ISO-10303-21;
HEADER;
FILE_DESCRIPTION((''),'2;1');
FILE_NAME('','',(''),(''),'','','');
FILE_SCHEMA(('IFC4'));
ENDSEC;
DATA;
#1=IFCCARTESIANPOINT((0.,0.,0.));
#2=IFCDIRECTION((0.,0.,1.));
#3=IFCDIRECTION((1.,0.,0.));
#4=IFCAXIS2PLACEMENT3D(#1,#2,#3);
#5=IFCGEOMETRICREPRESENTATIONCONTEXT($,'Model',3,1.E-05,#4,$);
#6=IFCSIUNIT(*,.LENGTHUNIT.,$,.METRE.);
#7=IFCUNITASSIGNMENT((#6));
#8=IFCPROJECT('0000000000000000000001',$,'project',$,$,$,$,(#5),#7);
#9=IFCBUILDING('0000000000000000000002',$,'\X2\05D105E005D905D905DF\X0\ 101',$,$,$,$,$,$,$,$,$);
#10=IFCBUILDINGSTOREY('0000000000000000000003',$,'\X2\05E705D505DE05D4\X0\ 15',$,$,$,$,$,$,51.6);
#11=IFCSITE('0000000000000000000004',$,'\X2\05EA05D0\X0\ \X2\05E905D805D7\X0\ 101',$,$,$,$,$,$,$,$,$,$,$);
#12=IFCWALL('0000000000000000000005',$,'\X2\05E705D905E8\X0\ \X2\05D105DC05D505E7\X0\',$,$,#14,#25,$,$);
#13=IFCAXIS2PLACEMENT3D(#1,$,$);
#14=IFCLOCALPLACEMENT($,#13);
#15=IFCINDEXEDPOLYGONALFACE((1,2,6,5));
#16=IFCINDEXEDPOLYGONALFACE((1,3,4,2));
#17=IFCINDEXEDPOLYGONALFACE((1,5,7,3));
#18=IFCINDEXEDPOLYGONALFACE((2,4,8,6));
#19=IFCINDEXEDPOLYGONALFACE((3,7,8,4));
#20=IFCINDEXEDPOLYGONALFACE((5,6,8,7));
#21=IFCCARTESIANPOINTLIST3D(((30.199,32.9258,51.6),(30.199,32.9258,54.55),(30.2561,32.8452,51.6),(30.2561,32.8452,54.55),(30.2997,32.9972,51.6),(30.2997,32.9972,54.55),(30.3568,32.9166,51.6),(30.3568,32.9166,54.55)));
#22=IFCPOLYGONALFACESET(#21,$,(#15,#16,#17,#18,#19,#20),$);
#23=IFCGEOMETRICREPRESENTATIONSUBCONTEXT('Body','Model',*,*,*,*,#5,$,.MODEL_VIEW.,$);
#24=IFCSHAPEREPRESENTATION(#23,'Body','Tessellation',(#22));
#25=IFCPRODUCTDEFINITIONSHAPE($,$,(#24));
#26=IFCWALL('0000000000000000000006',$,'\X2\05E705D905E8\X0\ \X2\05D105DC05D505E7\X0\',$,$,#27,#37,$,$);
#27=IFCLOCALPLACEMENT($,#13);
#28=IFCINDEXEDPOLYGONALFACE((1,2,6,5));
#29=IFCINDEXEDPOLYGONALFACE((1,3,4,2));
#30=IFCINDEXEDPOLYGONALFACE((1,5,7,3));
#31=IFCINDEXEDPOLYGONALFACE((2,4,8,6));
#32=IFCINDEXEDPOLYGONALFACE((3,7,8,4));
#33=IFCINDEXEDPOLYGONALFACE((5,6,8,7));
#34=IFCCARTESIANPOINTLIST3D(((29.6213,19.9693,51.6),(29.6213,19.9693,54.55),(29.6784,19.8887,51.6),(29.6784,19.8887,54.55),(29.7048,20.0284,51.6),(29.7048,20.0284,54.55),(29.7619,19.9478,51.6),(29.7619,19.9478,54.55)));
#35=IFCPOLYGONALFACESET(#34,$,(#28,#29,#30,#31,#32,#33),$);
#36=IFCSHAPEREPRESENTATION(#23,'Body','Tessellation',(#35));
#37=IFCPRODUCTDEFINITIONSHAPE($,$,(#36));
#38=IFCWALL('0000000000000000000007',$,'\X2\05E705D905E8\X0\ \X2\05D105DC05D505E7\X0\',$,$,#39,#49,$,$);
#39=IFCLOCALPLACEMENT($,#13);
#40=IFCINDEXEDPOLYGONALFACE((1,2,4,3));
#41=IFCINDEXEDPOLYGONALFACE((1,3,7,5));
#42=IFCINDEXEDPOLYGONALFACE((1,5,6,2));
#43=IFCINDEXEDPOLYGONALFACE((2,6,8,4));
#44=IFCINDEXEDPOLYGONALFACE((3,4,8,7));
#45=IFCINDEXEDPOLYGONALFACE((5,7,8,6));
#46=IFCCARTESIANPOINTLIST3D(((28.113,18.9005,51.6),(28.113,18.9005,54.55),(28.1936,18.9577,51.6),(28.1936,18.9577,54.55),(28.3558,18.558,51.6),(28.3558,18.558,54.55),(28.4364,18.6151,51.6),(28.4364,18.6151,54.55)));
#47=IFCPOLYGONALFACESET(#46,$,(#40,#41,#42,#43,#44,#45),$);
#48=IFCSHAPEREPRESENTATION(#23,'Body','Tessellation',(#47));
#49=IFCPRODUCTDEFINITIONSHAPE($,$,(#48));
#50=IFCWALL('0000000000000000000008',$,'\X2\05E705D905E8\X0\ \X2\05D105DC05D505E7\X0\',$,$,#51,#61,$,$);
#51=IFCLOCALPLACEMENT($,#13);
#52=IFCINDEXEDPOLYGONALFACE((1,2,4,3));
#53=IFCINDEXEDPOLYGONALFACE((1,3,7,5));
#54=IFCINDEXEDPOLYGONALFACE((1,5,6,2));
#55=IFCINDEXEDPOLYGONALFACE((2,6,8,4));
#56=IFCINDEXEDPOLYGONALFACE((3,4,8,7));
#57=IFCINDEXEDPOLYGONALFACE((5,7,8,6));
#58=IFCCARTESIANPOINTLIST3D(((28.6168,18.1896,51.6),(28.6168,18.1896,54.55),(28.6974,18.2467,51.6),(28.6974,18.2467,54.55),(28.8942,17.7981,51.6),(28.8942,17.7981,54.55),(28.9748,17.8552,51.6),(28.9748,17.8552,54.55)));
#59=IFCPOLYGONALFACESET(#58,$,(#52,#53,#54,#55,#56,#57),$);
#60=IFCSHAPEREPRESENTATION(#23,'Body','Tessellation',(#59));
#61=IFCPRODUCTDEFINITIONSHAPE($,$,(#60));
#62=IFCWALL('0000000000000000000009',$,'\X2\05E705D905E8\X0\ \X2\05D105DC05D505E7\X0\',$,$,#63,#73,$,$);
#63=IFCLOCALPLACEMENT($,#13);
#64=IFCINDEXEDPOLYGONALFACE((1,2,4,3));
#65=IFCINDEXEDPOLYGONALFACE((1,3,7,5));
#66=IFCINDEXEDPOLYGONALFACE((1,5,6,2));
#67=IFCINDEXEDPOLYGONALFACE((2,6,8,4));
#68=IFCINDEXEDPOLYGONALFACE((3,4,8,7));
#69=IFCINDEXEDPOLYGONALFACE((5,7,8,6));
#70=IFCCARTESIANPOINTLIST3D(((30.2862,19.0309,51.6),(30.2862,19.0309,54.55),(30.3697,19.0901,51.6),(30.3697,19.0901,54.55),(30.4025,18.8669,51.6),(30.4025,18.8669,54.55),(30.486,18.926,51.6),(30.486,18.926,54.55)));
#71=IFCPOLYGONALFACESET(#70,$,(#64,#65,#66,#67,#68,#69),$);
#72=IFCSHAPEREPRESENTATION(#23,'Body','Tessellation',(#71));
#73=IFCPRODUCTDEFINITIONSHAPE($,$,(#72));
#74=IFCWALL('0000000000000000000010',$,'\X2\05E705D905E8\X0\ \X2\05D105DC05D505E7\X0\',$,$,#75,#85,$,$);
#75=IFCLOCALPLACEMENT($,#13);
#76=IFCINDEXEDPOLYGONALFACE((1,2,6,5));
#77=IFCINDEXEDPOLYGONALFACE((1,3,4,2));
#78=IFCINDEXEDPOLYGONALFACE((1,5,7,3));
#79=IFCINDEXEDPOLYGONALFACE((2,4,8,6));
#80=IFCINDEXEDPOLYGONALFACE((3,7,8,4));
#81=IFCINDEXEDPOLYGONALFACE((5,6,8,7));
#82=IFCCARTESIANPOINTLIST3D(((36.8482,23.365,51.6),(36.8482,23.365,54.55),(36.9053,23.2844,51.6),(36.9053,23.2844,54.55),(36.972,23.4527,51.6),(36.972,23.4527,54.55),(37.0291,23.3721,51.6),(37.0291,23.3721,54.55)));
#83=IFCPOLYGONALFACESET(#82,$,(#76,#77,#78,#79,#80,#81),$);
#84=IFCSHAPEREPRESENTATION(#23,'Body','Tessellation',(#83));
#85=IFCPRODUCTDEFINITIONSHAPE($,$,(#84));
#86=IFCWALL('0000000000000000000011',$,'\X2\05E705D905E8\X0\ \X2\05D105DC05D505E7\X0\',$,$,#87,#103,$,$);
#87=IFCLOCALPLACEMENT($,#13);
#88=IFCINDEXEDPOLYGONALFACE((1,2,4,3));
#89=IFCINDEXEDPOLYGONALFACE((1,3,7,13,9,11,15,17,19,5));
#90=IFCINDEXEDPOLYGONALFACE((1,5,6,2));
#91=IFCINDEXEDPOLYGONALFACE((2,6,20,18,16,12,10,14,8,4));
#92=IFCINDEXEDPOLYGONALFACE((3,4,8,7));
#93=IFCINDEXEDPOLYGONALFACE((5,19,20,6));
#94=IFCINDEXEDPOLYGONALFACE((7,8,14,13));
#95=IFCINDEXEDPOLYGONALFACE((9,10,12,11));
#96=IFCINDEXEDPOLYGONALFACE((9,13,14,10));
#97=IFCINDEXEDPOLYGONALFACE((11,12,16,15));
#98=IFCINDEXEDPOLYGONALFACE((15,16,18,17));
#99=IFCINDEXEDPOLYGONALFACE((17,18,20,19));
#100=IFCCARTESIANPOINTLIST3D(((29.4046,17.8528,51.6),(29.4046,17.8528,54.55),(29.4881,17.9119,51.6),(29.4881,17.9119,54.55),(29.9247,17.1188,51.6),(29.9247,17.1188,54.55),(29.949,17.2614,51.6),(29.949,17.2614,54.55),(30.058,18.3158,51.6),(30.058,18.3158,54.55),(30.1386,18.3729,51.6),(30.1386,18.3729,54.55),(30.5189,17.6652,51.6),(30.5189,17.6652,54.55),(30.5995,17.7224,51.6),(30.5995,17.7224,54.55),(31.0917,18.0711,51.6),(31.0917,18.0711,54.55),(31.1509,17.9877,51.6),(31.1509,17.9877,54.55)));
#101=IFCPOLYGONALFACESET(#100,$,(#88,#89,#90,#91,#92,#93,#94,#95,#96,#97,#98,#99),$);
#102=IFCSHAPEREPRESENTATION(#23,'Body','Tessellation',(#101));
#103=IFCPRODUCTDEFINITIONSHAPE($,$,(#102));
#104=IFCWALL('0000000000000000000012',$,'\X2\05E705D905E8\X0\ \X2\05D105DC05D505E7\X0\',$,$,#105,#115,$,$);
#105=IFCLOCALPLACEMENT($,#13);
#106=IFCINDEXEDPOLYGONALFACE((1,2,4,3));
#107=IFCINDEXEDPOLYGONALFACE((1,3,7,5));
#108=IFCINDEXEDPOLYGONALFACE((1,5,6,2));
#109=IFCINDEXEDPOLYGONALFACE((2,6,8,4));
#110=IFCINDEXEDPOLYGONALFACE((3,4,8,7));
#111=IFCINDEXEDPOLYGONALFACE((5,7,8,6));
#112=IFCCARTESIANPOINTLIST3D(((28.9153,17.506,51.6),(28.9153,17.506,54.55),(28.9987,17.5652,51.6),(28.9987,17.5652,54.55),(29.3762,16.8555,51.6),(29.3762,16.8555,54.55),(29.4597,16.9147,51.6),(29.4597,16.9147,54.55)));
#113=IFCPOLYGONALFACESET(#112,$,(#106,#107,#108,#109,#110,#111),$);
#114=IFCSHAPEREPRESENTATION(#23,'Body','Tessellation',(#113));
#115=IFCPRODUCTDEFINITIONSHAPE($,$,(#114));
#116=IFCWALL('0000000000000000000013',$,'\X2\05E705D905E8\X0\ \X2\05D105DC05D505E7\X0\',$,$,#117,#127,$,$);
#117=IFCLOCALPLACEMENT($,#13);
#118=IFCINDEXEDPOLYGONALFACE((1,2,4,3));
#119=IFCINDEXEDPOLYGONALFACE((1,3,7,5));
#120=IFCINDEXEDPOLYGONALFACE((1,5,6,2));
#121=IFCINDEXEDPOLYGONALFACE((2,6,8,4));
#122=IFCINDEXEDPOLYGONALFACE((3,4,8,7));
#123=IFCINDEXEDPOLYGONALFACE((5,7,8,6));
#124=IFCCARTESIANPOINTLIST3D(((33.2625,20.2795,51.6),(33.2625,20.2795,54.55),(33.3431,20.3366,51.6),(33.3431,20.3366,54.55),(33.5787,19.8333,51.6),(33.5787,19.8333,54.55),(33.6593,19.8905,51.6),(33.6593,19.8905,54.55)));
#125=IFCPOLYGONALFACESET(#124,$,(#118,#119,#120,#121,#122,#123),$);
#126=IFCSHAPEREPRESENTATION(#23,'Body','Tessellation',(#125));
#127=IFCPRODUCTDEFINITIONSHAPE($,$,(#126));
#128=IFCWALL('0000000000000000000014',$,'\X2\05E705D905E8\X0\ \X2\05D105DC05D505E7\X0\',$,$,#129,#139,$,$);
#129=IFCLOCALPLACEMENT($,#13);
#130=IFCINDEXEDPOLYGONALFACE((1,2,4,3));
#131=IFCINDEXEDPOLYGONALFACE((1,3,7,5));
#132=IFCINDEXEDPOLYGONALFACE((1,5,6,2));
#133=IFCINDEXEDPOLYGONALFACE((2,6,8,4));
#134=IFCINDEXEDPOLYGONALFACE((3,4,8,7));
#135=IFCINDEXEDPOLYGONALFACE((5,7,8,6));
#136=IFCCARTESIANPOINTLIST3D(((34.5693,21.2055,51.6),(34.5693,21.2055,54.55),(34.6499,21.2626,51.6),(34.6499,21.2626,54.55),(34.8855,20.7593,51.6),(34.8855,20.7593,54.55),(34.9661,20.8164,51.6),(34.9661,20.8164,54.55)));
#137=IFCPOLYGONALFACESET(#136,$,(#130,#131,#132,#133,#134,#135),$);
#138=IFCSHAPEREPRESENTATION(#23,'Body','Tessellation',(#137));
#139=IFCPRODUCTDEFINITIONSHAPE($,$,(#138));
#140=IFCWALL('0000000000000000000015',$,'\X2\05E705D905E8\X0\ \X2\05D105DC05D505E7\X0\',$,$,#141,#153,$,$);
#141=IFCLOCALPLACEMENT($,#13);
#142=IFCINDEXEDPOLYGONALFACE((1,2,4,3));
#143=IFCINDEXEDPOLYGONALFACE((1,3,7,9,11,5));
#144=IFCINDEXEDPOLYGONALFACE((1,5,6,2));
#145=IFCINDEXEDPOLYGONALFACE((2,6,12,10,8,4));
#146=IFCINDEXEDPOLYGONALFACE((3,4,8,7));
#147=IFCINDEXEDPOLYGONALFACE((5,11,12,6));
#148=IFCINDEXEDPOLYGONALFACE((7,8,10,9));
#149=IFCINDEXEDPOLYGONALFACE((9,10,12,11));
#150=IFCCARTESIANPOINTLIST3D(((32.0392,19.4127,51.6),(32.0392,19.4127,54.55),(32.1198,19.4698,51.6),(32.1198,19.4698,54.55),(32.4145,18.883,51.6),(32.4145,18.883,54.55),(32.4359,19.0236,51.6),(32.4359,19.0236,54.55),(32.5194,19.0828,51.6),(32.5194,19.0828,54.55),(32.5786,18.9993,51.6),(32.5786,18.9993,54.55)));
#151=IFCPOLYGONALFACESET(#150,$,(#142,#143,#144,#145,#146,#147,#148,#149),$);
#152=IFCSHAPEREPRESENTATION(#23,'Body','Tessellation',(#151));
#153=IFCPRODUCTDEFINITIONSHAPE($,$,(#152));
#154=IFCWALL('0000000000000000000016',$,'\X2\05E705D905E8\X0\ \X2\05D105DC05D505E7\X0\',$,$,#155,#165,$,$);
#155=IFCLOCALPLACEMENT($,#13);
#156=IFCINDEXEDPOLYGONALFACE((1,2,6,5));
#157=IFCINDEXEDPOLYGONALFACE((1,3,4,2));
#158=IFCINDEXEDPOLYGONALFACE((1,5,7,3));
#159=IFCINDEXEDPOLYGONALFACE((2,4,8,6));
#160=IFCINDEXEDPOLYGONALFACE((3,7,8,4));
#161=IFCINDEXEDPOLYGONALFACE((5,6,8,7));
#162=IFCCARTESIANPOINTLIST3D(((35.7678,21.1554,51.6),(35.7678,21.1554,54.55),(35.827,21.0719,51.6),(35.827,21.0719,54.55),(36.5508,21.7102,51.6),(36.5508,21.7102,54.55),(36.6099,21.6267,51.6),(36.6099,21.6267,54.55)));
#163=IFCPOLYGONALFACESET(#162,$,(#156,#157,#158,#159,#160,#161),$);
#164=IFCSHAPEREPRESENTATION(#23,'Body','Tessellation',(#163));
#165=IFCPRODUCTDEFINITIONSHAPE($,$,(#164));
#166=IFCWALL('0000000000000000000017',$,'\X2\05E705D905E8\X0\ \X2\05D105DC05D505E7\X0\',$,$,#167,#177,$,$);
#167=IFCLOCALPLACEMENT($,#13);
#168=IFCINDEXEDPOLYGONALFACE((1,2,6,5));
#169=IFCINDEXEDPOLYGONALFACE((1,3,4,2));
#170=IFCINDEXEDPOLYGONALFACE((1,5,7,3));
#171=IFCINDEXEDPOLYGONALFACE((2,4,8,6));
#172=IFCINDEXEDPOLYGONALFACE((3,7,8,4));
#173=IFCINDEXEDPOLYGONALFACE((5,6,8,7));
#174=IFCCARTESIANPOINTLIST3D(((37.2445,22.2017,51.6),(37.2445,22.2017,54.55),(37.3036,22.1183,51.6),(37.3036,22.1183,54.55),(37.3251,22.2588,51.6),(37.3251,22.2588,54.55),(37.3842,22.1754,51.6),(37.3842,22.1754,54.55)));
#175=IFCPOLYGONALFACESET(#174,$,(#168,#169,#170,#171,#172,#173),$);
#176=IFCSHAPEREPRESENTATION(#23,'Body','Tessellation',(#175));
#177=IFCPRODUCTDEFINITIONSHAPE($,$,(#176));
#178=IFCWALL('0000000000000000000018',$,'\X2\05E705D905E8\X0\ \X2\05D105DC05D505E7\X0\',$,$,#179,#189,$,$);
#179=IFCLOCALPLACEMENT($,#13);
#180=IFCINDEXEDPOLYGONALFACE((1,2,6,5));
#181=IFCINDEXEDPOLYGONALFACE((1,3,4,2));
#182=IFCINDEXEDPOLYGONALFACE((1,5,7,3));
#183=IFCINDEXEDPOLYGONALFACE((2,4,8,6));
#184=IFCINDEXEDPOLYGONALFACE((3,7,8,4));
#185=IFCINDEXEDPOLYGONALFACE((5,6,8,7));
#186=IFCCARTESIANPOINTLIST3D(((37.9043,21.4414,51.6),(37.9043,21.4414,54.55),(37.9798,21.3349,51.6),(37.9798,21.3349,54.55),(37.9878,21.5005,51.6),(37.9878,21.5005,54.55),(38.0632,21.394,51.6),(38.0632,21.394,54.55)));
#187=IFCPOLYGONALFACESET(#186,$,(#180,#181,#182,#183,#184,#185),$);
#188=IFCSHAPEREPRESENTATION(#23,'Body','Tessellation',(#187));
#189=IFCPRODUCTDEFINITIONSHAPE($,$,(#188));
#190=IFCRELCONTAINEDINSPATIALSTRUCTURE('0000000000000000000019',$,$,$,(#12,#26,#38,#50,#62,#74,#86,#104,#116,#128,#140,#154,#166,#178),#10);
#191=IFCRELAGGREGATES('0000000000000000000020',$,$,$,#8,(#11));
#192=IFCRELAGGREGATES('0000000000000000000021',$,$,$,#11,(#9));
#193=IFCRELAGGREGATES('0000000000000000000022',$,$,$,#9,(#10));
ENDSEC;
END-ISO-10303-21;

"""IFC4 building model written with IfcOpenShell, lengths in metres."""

from ifc_helpers import new_model, si_unit, frame, origin_with_axes, context, subcontext, project, spatial, polyline, outline, extrude, element, save


model = new_model("IFC4")

# Units and contexts
model_context = context("Model", 3, precision=1e-05, world=origin_with_axes())
body_context = subcontext(model_context, "Body", "Model", "MODEL_VIEW")
ifc_project = project(units=[si_unit("LENGTHUNIT", "METRE")], contexts=[model_context])

# Site, building, storey
site = spatial("IfcSite", under=ifc_project, Name="תא שטח 101")
building = spatial("IfcBuilding", under=site, Name="בניין 101")
storey = spatial("IfcBuildingStorey", under=building, Name="קומה 15", Elevation=51.6)

# Walls
element("IfcWall", 1, inside=storey, Name="קיר בלוק", context=body_context, shape_type="SweptSolid", body=[
    extrude(outline(polyline([(30.2997, 32.9972), (30.199, 32.9258), (30.2561, 32.8452), (30.3568, 32.9166), (30.2997, 32.9972)])), frame((0.0, 0.0, 51.6)), (0.0, 0.0, 1.0), 2.95),
])
element("IfcWall", 2, inside=storey, Name="קיר בלוק", context=body_context, shape_type="SweptSolid", body=[
    extrude(outline(polyline([(29.6784, 19.8887), (29.7619, 19.9478), (29.7048, 20.0284), (29.6213, 19.9693), (29.6784, 19.8887)])), frame((0.0, 0.0, 51.6)), (0.0, 0.0, 1.0), 2.95),
])
element("IfcWall", 3, inside=storey, Name="קיר בלוק", context=body_context, shape_type="SweptSolid", body=[
    extrude(outline(polyline([(28.113, 18.9005), (28.3558, 18.558), (28.4364, 18.6151), (28.1936, 18.9577), (28.113, 18.9005)])), frame((0.0, 0.0, 51.6)), (0.0, 0.0, 1.0), 2.95),
])
element("IfcWall", 4, inside=storey, Name="קיר בלוק", context=body_context, shape_type="SweptSolid", body=[
    extrude(outline(polyline([(28.6974, 18.2467), (28.6168, 18.1896), (28.8942, 17.7981), (28.9748, 17.8552), (28.6974, 18.2467)])), frame((0.0, 0.0, 51.6)), (0.0, 0.0, 1.0), 2.95),
])
element("IfcWall", 5, inside=storey, Name="קיר בלוק", context=body_context, shape_type="SweptSolid", body=[
    extrude(outline(polyline([(30.4025, 18.8669), (30.486, 18.926), (30.3697, 19.0901), (30.2862, 19.0309), (30.4025, 18.8669)])), frame((0.0, 0.0, 51.6)), (0.0, 0.0, 1.0), 2.95),
])
element("IfcWall", 6, inside=storey, Name="קיר בלוק", context=body_context, shape_type="SweptSolid", body=[
    extrude(outline(polyline([(36.8482, 23.365), (36.9053, 23.2844), (37.0291, 23.3721), (36.972, 23.4527), (36.8482, 23.365)])), frame((0.0, 0.0, 51.6)), (0.0, 0.0, 1.0), 2.95),
])
element("IfcWall", 7, inside=storey, Name="קיר בלוק", context=body_context, shape_type="SweptSolid", body=[
    extrude(outline(polyline([(30.5189, 17.6652), (29.949, 17.2614), (29.4881, 17.9119), (29.4046, 17.8528), (29.9247, 17.1188), (31.1509, 17.9877), (31.0917, 18.0711), (30.5995, 17.7224), (30.1386, 18.3729), (30.058, 18.3158), (30.5189, 17.6652)])), frame((0.0, 0.0, 51.6)), (0.0, 0.0, 1.0), 2.95),
])
element("IfcWall", 8, inside=storey, Name="קיר בלוק", context=body_context, shape_type="SweptSolid", body=[
    extrude(outline(polyline([(28.9987, 17.5652), (28.9153, 17.506), (29.3762, 16.8555), (29.4597, 16.9147), (28.9987, 17.5652)])), frame((0.0, 0.0, 51.6)), (0.0, 0.0, 1.0), 2.95),
])
element("IfcWall", 9, inside=storey, Name="קיר בלוק", context=body_context, shape_type="SweptSolid", body=[
    extrude(outline(polyline([(33.5787, 19.8333), (33.6593, 19.8905), (33.3431, 20.3366), (33.2625, 20.2795), (33.5787, 19.8333)])), frame((0.0, 0.0, 51.6)), (0.0, 0.0, 1.0), 2.95),
])
element("IfcWall", 10, inside=storey, Name="קיר בלוק", context=body_context, shape_type="SweptSolid", body=[
    extrude(outline(polyline([(34.9661, 20.8164), (34.6499, 21.2626), (34.5693, 21.2055), (34.8855, 20.7593), (34.9661, 20.8164)])), frame((0.0, 0.0, 51.6)), (0.0, 0.0, 1.0), 2.95),
])
element("IfcWall", 11, inside=storey, Name="קיר בלוק", context=body_context, shape_type="SweptSolid", body=[
    extrude(outline(polyline([(32.5194, 19.0828), (32.4359, 19.0236), (32.1198, 19.4698), (32.0392, 19.4127), (32.4145, 18.883), (32.5786, 18.9993), (32.5194, 19.0828)])), frame((0.0, 0.0, 51.6)), (0.0, 0.0, 1.0), 2.95),
])
element("IfcWall", 12, inside=storey, Name="קיר בלוק", context=body_context, shape_type="SweptSolid", body=[
    extrude(outline(polyline([(36.6099, 21.6267), (36.5508, 21.7102), (35.7678, 21.1554), (35.827, 21.0719), (36.6099, 21.6267)])), frame((0.0, 0.0, 51.6)), (0.0, 0.0, 1.0), 2.95),
])
element("IfcWall", 13, inside=storey, Name="קיר בלוק", context=body_context, shape_type="SweptSolid", body=[
    extrude(outline(polyline([(37.2445, 22.2017), (37.3036, 22.1183), (37.3842, 22.1754), (37.3251, 22.2588), (37.2445, 22.2017)])), frame((0.0, 0.0, 51.6)), (0.0, 0.0, 1.0), 2.95),
])
element("IfcWall", 14, inside=storey, Name="קיר בלוק", context=body_context, shape_type="SweptSolid", body=[
    extrude(outline(polyline([(37.9878, 21.5005), (37.9043, 21.4414), (37.9798, 21.3349), (38.0632, 21.394), (37.9878, 21.5005)])), frame((0.0, 0.0, 51.6)), (0.0, 0.0, 1.0), 2.95),
])

save(model, "model.ifc")
